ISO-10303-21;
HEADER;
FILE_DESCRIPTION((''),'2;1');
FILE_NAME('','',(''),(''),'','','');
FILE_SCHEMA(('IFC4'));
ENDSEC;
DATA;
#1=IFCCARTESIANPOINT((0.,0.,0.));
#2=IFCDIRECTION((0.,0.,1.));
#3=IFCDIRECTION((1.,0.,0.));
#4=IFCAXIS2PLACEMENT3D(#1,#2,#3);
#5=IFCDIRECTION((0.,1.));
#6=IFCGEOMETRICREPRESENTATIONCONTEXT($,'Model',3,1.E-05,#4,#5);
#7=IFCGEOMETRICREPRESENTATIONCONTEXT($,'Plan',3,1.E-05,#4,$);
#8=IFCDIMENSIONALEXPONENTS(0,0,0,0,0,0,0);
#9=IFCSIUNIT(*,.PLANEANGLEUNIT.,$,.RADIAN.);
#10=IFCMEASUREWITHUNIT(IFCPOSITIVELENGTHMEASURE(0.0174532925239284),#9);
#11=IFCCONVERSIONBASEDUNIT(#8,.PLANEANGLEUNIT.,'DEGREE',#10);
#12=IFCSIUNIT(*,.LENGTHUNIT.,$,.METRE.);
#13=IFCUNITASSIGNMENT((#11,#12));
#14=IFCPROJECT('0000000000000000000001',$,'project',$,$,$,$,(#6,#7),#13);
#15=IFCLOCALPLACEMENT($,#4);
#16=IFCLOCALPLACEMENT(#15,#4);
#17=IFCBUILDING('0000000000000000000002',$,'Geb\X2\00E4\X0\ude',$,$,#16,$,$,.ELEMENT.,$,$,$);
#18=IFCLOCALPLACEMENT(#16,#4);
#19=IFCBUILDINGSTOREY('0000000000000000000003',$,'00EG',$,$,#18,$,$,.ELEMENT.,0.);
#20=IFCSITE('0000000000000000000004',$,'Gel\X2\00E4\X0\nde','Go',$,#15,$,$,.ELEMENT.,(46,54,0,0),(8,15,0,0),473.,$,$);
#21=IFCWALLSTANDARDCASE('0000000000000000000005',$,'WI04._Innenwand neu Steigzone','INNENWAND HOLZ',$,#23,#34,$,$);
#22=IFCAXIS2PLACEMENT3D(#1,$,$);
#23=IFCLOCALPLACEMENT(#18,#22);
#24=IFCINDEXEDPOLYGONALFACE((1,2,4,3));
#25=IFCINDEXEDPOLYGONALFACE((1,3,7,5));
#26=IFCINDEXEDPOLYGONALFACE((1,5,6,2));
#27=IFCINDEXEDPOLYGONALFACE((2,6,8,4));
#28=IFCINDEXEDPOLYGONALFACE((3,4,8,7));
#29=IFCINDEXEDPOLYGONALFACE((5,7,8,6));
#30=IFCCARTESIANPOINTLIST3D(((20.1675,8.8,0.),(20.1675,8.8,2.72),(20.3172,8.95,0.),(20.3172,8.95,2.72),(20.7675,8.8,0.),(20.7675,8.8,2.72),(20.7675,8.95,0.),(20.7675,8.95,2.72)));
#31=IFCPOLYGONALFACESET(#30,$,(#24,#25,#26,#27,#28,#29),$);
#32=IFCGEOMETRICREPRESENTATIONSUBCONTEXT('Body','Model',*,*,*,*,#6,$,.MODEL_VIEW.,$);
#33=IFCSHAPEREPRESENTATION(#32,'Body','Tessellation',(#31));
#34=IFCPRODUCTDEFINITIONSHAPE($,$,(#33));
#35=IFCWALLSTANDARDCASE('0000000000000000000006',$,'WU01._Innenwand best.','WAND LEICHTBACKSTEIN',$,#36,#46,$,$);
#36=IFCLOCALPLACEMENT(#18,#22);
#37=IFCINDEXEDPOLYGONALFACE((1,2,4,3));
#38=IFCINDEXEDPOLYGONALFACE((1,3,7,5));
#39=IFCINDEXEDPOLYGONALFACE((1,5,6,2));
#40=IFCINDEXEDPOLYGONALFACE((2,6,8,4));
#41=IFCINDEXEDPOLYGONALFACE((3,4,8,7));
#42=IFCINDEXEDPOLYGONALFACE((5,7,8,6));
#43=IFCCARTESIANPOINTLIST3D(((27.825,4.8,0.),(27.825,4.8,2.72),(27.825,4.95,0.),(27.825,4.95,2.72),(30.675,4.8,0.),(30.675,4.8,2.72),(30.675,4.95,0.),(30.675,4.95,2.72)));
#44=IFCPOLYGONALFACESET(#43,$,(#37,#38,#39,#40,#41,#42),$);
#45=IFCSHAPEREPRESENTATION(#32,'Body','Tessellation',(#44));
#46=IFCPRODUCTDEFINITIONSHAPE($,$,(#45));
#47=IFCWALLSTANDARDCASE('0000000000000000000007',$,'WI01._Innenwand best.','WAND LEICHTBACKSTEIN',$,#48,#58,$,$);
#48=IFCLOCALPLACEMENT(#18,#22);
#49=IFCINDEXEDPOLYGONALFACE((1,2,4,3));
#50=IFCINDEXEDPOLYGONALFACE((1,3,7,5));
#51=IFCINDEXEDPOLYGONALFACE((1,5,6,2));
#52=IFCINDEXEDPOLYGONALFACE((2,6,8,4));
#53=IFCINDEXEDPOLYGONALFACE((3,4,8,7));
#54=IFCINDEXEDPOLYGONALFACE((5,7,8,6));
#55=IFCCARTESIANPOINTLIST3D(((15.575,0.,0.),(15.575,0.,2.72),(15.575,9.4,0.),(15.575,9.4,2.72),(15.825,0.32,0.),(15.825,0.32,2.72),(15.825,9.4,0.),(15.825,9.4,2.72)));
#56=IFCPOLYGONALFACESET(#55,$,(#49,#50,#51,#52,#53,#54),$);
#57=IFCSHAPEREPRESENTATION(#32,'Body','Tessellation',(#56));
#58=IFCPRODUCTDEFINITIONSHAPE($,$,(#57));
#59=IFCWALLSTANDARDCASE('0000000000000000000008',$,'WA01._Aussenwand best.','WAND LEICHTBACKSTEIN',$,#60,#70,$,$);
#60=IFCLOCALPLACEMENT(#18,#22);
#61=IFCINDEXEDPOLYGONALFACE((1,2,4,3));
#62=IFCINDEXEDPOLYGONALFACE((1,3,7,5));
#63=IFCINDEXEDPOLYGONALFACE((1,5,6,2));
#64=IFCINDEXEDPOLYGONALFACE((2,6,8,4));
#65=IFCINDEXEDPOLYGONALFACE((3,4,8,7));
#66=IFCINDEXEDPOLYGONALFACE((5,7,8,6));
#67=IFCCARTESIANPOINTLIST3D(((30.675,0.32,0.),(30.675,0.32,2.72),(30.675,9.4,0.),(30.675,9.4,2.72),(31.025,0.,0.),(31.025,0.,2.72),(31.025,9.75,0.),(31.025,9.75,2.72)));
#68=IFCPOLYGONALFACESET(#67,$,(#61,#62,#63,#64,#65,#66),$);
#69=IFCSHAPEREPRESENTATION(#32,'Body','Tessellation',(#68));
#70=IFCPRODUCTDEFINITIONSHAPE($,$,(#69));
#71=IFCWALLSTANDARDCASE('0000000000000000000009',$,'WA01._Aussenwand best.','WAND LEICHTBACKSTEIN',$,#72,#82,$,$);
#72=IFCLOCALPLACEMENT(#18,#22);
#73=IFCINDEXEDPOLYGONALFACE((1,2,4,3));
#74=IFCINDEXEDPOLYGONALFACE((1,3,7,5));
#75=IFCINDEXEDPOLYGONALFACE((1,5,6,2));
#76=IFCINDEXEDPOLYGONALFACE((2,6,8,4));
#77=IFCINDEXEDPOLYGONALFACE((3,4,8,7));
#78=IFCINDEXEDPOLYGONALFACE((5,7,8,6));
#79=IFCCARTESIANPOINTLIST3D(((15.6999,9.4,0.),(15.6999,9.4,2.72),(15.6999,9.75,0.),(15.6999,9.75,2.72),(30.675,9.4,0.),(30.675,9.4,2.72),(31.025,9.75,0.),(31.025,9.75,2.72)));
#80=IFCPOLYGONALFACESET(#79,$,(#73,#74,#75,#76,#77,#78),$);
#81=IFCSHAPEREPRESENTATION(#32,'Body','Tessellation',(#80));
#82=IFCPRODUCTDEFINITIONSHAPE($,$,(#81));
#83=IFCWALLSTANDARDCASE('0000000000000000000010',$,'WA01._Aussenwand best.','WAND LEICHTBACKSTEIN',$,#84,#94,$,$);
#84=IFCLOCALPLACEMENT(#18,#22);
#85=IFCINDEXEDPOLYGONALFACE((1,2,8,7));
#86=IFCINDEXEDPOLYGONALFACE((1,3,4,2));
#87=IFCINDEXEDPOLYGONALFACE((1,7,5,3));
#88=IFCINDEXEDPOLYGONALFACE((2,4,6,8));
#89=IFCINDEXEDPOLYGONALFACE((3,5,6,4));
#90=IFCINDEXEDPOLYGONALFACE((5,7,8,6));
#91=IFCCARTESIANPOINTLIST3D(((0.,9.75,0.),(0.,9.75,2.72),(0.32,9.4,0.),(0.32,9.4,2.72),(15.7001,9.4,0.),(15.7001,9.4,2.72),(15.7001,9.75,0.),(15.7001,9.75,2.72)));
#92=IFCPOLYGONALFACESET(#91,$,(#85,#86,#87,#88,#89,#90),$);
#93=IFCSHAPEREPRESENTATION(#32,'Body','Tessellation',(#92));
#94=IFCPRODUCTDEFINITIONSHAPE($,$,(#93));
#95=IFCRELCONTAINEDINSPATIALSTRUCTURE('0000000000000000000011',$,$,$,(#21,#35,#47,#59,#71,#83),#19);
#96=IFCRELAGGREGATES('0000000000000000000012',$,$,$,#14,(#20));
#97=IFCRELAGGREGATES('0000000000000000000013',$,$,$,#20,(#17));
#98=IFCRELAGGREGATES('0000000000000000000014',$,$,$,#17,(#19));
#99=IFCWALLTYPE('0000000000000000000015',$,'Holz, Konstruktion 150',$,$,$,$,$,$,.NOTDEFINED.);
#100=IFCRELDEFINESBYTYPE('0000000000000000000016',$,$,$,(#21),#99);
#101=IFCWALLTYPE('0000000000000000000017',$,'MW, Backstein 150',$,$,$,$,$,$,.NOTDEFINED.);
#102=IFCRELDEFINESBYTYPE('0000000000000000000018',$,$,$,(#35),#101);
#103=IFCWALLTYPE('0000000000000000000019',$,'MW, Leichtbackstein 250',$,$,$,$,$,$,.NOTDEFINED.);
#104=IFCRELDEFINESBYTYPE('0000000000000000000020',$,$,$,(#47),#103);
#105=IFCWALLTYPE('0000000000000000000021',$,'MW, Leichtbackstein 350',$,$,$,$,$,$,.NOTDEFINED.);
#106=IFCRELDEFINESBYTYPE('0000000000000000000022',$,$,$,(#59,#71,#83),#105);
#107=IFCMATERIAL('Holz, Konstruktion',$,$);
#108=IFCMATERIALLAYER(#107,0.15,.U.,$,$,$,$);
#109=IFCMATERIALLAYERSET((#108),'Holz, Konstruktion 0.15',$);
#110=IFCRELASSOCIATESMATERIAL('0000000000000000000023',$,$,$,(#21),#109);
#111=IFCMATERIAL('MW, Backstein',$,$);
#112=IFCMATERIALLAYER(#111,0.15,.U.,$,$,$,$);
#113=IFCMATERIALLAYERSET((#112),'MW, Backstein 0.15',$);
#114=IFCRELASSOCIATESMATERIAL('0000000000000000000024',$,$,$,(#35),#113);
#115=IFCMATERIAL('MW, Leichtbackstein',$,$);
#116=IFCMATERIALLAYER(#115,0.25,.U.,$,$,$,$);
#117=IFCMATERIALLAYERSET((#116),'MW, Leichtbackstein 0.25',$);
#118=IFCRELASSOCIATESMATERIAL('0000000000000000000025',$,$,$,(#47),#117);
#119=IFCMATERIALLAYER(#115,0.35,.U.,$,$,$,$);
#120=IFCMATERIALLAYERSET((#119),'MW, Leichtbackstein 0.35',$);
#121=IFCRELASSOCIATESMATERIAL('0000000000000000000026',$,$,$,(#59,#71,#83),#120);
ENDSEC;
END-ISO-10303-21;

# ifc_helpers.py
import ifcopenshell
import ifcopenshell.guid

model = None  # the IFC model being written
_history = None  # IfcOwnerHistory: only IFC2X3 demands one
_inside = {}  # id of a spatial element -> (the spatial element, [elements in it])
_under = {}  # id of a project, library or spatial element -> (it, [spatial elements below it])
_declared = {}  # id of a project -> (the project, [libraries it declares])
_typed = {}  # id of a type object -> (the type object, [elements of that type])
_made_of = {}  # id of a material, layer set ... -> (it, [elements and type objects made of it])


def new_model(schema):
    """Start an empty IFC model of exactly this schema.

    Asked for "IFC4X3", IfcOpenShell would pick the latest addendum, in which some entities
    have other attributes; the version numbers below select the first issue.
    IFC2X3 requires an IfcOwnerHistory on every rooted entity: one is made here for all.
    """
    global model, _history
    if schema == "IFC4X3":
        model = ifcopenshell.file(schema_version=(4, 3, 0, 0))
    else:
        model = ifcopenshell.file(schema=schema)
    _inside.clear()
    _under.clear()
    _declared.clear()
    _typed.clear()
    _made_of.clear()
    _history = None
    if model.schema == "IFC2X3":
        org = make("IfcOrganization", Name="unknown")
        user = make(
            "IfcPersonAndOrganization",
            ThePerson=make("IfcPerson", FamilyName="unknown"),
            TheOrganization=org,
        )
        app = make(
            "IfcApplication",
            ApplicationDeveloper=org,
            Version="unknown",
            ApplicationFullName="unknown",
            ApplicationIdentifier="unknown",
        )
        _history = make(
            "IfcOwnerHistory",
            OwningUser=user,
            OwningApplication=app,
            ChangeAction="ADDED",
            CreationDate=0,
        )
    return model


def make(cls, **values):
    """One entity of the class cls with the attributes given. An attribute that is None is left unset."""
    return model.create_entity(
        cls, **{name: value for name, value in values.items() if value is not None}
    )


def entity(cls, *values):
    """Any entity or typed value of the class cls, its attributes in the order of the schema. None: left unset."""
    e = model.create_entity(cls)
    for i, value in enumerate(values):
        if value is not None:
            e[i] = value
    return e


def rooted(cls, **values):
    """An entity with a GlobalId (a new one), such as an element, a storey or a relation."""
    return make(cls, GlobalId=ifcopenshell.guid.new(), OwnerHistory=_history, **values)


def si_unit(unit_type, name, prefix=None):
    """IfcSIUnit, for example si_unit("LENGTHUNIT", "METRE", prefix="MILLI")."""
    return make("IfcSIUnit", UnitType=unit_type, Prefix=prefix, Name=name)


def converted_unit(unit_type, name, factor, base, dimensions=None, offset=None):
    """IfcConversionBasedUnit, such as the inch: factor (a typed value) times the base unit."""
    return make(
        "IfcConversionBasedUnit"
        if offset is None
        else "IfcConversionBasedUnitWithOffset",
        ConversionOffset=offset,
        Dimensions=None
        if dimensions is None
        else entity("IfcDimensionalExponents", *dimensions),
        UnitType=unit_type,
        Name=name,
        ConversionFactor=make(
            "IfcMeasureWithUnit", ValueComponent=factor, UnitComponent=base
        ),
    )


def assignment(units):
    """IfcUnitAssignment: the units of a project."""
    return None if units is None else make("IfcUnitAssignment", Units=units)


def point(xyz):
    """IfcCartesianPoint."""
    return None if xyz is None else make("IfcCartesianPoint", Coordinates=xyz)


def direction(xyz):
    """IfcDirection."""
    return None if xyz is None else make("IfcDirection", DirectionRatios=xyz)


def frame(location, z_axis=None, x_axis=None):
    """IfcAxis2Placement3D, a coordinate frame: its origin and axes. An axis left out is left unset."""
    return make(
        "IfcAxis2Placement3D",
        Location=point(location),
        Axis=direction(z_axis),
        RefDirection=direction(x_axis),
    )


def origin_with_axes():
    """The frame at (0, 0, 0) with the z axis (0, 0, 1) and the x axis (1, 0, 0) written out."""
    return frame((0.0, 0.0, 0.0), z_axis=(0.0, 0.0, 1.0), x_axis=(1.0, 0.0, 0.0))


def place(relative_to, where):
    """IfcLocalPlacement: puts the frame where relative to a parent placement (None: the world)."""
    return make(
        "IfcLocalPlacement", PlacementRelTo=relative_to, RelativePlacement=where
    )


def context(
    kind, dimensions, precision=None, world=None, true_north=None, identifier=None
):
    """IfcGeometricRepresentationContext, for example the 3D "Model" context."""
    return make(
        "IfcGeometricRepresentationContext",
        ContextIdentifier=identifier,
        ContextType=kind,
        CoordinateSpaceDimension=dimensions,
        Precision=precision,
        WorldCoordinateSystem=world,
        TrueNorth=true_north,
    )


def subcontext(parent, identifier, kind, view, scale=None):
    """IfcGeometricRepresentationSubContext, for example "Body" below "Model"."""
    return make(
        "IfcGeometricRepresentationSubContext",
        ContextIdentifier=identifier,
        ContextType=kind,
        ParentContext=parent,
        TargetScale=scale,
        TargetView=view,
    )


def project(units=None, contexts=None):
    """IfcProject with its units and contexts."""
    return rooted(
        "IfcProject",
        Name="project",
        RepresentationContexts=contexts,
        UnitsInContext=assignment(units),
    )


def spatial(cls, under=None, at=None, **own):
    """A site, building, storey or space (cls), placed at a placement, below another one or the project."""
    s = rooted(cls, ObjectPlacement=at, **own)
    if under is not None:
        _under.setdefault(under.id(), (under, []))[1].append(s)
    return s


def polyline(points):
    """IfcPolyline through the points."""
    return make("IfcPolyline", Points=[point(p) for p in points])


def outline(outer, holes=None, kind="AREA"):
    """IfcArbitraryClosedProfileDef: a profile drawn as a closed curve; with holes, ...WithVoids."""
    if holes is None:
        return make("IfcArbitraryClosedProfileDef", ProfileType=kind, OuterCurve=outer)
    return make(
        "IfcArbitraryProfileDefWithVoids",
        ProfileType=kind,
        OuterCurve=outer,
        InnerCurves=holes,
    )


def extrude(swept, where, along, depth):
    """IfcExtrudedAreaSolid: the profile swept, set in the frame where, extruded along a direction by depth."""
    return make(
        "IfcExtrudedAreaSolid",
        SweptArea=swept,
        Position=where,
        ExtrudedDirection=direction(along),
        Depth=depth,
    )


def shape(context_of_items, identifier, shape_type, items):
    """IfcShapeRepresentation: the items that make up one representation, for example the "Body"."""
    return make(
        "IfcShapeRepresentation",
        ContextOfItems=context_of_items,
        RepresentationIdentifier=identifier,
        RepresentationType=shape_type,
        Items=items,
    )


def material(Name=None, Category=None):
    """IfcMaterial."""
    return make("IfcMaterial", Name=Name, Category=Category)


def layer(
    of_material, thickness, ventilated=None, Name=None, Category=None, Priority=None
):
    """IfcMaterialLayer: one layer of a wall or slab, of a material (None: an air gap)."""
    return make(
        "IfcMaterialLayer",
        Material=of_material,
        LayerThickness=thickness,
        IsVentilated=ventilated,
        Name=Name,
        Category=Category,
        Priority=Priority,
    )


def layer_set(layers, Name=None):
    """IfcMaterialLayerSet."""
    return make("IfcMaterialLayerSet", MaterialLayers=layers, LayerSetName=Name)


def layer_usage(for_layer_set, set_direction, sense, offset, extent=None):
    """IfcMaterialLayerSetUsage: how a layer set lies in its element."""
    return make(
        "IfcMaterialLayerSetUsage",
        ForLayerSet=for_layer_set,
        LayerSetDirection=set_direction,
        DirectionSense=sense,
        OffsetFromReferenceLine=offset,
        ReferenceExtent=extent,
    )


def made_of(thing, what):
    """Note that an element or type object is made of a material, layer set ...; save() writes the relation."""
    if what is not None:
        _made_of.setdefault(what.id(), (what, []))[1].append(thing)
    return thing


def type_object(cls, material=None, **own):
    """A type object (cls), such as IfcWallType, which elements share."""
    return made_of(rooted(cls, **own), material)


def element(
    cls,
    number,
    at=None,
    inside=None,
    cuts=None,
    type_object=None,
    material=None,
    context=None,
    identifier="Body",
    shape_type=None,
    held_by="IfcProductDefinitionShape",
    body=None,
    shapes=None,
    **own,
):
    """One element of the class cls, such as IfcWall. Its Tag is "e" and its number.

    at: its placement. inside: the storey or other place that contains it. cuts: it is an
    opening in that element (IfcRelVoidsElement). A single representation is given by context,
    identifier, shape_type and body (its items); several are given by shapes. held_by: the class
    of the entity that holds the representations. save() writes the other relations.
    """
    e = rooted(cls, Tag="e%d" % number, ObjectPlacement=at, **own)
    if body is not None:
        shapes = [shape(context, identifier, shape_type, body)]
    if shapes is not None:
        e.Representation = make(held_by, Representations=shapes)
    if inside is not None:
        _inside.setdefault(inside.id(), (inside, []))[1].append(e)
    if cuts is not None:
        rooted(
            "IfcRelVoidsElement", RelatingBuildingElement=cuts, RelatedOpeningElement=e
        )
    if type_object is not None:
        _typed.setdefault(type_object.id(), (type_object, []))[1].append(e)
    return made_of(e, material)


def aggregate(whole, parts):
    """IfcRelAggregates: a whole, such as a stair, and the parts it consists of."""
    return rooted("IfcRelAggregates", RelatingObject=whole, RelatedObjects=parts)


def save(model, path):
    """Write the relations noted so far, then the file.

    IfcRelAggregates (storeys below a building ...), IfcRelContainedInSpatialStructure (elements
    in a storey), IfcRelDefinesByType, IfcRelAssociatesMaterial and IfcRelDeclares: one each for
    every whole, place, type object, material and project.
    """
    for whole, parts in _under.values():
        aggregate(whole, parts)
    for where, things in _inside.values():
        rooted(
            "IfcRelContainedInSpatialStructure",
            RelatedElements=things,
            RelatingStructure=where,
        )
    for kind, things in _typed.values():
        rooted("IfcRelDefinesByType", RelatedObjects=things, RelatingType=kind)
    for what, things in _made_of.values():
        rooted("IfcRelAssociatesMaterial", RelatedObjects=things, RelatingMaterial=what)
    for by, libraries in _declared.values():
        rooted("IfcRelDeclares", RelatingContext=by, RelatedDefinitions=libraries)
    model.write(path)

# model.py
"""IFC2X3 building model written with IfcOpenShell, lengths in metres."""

from ifc_helpers import new_model, entity, si_unit, converted_unit, direction, frame, origin_with_axes, place, context, subcontext, project, spatial, polyline, outline, extrude, material, layer, layer_set, layer_usage, type_object, element, save


model = new_model("IFC2X3")

# Units and contexts
model_context = context("Model", 3, precision=1e-05, world=origin_with_axes(), true_north=direction((0.0, 1.0)))
plan_context = context("Plan", 3, precision=1e-05, world=origin_with_axes())
body_context = subcontext(model_context, "Body", "Model", "MODEL_VIEW")
ifc_project = project(units=[converted_unit("PLANEANGLEUNIT", "DEGREE", entity("IfcPositiveLengthMeasure", 0.0174532925239284), si_unit("PLANEANGLEUNIT", "RADIAN"), dimensions=[0, 0, 0, 0, 0, 0, 0]), si_unit("LENGTHUNIT", "METRE")], contexts=[model_context, plan_context])

# Site, building, storey
site_placement = place(None, origin_with_axes())
site = spatial("IfcSite", under=ifc_project, at=site_placement, Name="Gelände", Description="Go", CompositionType="ELEMENT", RefLatitude=(46, 54, 0, 0), RefLongitude=(8, 15, 0, 0), RefElevation=473.0)
building_placement = place(site_placement, origin_with_axes())
building = spatial("IfcBuilding", under=site, at=building_placement, Name="Gebäude", CompositionType="ELEMENT")
storey_placement = place(building_placement, origin_with_axes())
storey = spatial("IfcBuildingStorey", under=building, at=storey_placement, Name="00EG", CompositionType="ELEMENT", Elevation=0.0)

# Shared definitions
ifc_material_1 = material(Name="Holz, Konstruktion")

# Walls
ifc_layer_1 = layer(ifc_material_1, 0.15, ventilated="UNKNOWN")
ifc_layer_set_1 = layer_set([ifc_layer_1], Name="Holz, Konstruktion 0.15")
wall_type_1 = type_object("IfcWallType", Name="Holz, Konstruktion 150", PredefinedType="NOTDEFINED")
ifc_layer_usage_1 = layer_usage(ifc_layer_set_1, "AXIS2", "POSITIVE", 0.0)
wall_1_placement = place(storey_placement, frame((20.1675, 8.8, 0.0), z_axis=(0.0, 0.0, 1.0), x_axis=(1.0, 0.0, 0.0)))
element("IfcWallStandardCase", 1, at=wall_1_placement, inside=storey, type_object=wall_type_1, material=ifc_layer_usage_1, Name="WI04._Innenwand neu Steigzone", Description="INNENWAND HOLZ", context=body_context, shape_type="SweptSolid", body=[
    extrude(outline(polyline([(0.0, 0.0), (0.6, 0.0), (0.6, 0.15), (0.1497, 0.15), (0.0, 0.0)])), origin_with_axes(), (0.0, 0.0, 1.0), 2.72),
])
ifc_material_2 = material(Name="MW, Backstein")
ifc_layer_2 = layer(ifc_material_2, 0.15, ventilated="UNKNOWN")
ifc_layer_set_2 = layer_set([ifc_layer_2], Name="MW, Backstein 0.15")
ifc_layer_usage_2 = layer_usage(ifc_layer_set_2, "AXIS2", "NEGATIVE", 0.15)
wall_type_2 = type_object("IfcWallType", Name="MW, Backstein 150", PredefinedType="NOTDEFINED")
wall_2_placement = place(storey_placement, frame((30.675, 4.95, 0.0), z_axis=(0.0, 0.0, 1.0), x_axis=(-1.0, 0.0, 0.0)))
element("IfcWallStandardCase", 2, at=wall_2_placement, inside=storey, type_object=wall_type_2, material=ifc_layer_usage_2, Name="WU01._Innenwand best.", Description="WAND LEICHTBACKSTEIN", context=body_context, shape_type="SweptSolid", body=[
    extrude(outline(polyline([(0.0, 0.0), (2.85, 0.0), (2.85, 0.15), (0.0, 0.15), (0.0, 0.0)])), origin_with_axes(), (0.0, 0.0, 1.0), 2.72),
])
ifc_material_3 = material(Name="MW, Leichtbackstein")
ifc_layer_3 = layer(ifc_material_3, 0.25, ventilated="UNKNOWN")
ifc_layer_set_3 = layer_set([ifc_layer_3], Name="MW, Leichtbackstein 0.25")
ifc_layer_usage_3 = layer_usage(ifc_layer_set_3, "AXIS2", "NEGATIVE", 0.0)
wall_type_3 = type_object("IfcWallType", Name="MW, Leichtbackstein 250", PredefinedType="NOTDEFINED")
wall_3_placement = place(storey_placement, frame((15.825, 9.4, 0.0), z_axis=(0.0, 0.0, 1.0), x_axis=(0.0, -1.0, 0.0)))
element("IfcWallStandardCase", 3, at=wall_3_placement, inside=storey, type_object=wall_type_3, material=ifc_layer_usage_3, Name="WI01._Innenwand best.", Description="WAND LEICHTBACKSTEIN", context=body_context, shape_type="SweptSolid", body=[
    extrude(outline(polyline([(0.0, -0.25), (9.4, -0.25), (9.08, 0.0), (0.0, 0.0), (0.0, -0.25)])), origin_with_axes(), (0.0, 0.0, 1.0), 2.72),
])
ifc_layer_4 = layer(ifc_material_3, 0.35, ventilated="UNKNOWN")
ifc_layer_set_4 = layer_set([ifc_layer_4], Name="MW, Leichtbackstein 0.35")
ifc_layer_usage_4 = layer_usage(ifc_layer_set_4, "AXIS2", "NEGATIVE", 0.35)
wall_type_4 = type_object("IfcWallType", Name="MW, Leichtbackstein 350", PredefinedType="NOTDEFINED")
wall_4_placement = place(storey_placement, frame((30.675, 9.4, 0.0), z_axis=(0.0, 0.0, 1.0), x_axis=(0.0, -1.0, 0.0)))
element("IfcWallStandardCase", 4, at=wall_4_placement, inside=storey, type_object=wall_type_4, material=ifc_layer_usage_4, Name="WA01._Aussenwand best.", Description="WAND LEICHTBACKSTEIN", context=body_context, shape_type="SweptSolid", body=[
    extrude(outline(polyline([(0.0, 0.0), (9.08, 0.0), (9.4, 0.35), (-0.35, 0.35), (0.0, 0.0)])), origin_with_axes(), (0.0, 0.0, 1.0), 2.72),
])
ifc_layer_usage_5 = layer_usage(ifc_layer_set_4, "AXIS2", "NEGATIVE", 0.35)
wall_5_placement = place(storey_placement, frame((15.6999, 9.4, 0.0), z_axis=(0.0, 0.0, 1.0), x_axis=(1.0, 0.0, 0.0)))
element("IfcWallStandardCase", 5, at=wall_5_placement, inside=storey, type_object=wall_type_4, material=ifc_layer_usage_5, Name="WA01._Aussenwand best.", Description="WAND LEICHTBACKSTEIN", context=body_context, shape_type="SweptSolid", body=[
    extrude(outline(polyline([(0.0, 0.0), (14.9751, 0.0), (15.3251, 0.35), (0.0, 0.35), (0.0, 0.0)])), origin_with_axes(), (0.0, 0.0, 1.0), 2.72),
])
ifc_layer_usage_6 = layer_usage(ifc_layer_set_4, "AXIS2", "POSITIVE", -0.35)
wall_6_placement = place(storey_placement, frame((15.7001, 9.4, 0.0), z_axis=(0.0, 0.0, 1.0), x_axis=(-1.0, 0.0, 0.0)))
element("IfcWallStandardCase", 6, at=wall_6_placement, inside=storey, type_object=wall_type_4, material=ifc_layer_usage_6, Name="WA01._Aussenwand best.", Description="WAND LEICHTBACKSTEIN", context=body_context, shape_type="SweptSolid", body=[
    extrude(outline(polyline([(0.0, -0.35), (15.7001, -0.35), (15.3801, 0.0), (0.0, 0.0), (0.0, -0.35)])), origin_with_axes(), (0.0, 0.0, 1.0), 2.72),
])

save(model, "model.ifc")
